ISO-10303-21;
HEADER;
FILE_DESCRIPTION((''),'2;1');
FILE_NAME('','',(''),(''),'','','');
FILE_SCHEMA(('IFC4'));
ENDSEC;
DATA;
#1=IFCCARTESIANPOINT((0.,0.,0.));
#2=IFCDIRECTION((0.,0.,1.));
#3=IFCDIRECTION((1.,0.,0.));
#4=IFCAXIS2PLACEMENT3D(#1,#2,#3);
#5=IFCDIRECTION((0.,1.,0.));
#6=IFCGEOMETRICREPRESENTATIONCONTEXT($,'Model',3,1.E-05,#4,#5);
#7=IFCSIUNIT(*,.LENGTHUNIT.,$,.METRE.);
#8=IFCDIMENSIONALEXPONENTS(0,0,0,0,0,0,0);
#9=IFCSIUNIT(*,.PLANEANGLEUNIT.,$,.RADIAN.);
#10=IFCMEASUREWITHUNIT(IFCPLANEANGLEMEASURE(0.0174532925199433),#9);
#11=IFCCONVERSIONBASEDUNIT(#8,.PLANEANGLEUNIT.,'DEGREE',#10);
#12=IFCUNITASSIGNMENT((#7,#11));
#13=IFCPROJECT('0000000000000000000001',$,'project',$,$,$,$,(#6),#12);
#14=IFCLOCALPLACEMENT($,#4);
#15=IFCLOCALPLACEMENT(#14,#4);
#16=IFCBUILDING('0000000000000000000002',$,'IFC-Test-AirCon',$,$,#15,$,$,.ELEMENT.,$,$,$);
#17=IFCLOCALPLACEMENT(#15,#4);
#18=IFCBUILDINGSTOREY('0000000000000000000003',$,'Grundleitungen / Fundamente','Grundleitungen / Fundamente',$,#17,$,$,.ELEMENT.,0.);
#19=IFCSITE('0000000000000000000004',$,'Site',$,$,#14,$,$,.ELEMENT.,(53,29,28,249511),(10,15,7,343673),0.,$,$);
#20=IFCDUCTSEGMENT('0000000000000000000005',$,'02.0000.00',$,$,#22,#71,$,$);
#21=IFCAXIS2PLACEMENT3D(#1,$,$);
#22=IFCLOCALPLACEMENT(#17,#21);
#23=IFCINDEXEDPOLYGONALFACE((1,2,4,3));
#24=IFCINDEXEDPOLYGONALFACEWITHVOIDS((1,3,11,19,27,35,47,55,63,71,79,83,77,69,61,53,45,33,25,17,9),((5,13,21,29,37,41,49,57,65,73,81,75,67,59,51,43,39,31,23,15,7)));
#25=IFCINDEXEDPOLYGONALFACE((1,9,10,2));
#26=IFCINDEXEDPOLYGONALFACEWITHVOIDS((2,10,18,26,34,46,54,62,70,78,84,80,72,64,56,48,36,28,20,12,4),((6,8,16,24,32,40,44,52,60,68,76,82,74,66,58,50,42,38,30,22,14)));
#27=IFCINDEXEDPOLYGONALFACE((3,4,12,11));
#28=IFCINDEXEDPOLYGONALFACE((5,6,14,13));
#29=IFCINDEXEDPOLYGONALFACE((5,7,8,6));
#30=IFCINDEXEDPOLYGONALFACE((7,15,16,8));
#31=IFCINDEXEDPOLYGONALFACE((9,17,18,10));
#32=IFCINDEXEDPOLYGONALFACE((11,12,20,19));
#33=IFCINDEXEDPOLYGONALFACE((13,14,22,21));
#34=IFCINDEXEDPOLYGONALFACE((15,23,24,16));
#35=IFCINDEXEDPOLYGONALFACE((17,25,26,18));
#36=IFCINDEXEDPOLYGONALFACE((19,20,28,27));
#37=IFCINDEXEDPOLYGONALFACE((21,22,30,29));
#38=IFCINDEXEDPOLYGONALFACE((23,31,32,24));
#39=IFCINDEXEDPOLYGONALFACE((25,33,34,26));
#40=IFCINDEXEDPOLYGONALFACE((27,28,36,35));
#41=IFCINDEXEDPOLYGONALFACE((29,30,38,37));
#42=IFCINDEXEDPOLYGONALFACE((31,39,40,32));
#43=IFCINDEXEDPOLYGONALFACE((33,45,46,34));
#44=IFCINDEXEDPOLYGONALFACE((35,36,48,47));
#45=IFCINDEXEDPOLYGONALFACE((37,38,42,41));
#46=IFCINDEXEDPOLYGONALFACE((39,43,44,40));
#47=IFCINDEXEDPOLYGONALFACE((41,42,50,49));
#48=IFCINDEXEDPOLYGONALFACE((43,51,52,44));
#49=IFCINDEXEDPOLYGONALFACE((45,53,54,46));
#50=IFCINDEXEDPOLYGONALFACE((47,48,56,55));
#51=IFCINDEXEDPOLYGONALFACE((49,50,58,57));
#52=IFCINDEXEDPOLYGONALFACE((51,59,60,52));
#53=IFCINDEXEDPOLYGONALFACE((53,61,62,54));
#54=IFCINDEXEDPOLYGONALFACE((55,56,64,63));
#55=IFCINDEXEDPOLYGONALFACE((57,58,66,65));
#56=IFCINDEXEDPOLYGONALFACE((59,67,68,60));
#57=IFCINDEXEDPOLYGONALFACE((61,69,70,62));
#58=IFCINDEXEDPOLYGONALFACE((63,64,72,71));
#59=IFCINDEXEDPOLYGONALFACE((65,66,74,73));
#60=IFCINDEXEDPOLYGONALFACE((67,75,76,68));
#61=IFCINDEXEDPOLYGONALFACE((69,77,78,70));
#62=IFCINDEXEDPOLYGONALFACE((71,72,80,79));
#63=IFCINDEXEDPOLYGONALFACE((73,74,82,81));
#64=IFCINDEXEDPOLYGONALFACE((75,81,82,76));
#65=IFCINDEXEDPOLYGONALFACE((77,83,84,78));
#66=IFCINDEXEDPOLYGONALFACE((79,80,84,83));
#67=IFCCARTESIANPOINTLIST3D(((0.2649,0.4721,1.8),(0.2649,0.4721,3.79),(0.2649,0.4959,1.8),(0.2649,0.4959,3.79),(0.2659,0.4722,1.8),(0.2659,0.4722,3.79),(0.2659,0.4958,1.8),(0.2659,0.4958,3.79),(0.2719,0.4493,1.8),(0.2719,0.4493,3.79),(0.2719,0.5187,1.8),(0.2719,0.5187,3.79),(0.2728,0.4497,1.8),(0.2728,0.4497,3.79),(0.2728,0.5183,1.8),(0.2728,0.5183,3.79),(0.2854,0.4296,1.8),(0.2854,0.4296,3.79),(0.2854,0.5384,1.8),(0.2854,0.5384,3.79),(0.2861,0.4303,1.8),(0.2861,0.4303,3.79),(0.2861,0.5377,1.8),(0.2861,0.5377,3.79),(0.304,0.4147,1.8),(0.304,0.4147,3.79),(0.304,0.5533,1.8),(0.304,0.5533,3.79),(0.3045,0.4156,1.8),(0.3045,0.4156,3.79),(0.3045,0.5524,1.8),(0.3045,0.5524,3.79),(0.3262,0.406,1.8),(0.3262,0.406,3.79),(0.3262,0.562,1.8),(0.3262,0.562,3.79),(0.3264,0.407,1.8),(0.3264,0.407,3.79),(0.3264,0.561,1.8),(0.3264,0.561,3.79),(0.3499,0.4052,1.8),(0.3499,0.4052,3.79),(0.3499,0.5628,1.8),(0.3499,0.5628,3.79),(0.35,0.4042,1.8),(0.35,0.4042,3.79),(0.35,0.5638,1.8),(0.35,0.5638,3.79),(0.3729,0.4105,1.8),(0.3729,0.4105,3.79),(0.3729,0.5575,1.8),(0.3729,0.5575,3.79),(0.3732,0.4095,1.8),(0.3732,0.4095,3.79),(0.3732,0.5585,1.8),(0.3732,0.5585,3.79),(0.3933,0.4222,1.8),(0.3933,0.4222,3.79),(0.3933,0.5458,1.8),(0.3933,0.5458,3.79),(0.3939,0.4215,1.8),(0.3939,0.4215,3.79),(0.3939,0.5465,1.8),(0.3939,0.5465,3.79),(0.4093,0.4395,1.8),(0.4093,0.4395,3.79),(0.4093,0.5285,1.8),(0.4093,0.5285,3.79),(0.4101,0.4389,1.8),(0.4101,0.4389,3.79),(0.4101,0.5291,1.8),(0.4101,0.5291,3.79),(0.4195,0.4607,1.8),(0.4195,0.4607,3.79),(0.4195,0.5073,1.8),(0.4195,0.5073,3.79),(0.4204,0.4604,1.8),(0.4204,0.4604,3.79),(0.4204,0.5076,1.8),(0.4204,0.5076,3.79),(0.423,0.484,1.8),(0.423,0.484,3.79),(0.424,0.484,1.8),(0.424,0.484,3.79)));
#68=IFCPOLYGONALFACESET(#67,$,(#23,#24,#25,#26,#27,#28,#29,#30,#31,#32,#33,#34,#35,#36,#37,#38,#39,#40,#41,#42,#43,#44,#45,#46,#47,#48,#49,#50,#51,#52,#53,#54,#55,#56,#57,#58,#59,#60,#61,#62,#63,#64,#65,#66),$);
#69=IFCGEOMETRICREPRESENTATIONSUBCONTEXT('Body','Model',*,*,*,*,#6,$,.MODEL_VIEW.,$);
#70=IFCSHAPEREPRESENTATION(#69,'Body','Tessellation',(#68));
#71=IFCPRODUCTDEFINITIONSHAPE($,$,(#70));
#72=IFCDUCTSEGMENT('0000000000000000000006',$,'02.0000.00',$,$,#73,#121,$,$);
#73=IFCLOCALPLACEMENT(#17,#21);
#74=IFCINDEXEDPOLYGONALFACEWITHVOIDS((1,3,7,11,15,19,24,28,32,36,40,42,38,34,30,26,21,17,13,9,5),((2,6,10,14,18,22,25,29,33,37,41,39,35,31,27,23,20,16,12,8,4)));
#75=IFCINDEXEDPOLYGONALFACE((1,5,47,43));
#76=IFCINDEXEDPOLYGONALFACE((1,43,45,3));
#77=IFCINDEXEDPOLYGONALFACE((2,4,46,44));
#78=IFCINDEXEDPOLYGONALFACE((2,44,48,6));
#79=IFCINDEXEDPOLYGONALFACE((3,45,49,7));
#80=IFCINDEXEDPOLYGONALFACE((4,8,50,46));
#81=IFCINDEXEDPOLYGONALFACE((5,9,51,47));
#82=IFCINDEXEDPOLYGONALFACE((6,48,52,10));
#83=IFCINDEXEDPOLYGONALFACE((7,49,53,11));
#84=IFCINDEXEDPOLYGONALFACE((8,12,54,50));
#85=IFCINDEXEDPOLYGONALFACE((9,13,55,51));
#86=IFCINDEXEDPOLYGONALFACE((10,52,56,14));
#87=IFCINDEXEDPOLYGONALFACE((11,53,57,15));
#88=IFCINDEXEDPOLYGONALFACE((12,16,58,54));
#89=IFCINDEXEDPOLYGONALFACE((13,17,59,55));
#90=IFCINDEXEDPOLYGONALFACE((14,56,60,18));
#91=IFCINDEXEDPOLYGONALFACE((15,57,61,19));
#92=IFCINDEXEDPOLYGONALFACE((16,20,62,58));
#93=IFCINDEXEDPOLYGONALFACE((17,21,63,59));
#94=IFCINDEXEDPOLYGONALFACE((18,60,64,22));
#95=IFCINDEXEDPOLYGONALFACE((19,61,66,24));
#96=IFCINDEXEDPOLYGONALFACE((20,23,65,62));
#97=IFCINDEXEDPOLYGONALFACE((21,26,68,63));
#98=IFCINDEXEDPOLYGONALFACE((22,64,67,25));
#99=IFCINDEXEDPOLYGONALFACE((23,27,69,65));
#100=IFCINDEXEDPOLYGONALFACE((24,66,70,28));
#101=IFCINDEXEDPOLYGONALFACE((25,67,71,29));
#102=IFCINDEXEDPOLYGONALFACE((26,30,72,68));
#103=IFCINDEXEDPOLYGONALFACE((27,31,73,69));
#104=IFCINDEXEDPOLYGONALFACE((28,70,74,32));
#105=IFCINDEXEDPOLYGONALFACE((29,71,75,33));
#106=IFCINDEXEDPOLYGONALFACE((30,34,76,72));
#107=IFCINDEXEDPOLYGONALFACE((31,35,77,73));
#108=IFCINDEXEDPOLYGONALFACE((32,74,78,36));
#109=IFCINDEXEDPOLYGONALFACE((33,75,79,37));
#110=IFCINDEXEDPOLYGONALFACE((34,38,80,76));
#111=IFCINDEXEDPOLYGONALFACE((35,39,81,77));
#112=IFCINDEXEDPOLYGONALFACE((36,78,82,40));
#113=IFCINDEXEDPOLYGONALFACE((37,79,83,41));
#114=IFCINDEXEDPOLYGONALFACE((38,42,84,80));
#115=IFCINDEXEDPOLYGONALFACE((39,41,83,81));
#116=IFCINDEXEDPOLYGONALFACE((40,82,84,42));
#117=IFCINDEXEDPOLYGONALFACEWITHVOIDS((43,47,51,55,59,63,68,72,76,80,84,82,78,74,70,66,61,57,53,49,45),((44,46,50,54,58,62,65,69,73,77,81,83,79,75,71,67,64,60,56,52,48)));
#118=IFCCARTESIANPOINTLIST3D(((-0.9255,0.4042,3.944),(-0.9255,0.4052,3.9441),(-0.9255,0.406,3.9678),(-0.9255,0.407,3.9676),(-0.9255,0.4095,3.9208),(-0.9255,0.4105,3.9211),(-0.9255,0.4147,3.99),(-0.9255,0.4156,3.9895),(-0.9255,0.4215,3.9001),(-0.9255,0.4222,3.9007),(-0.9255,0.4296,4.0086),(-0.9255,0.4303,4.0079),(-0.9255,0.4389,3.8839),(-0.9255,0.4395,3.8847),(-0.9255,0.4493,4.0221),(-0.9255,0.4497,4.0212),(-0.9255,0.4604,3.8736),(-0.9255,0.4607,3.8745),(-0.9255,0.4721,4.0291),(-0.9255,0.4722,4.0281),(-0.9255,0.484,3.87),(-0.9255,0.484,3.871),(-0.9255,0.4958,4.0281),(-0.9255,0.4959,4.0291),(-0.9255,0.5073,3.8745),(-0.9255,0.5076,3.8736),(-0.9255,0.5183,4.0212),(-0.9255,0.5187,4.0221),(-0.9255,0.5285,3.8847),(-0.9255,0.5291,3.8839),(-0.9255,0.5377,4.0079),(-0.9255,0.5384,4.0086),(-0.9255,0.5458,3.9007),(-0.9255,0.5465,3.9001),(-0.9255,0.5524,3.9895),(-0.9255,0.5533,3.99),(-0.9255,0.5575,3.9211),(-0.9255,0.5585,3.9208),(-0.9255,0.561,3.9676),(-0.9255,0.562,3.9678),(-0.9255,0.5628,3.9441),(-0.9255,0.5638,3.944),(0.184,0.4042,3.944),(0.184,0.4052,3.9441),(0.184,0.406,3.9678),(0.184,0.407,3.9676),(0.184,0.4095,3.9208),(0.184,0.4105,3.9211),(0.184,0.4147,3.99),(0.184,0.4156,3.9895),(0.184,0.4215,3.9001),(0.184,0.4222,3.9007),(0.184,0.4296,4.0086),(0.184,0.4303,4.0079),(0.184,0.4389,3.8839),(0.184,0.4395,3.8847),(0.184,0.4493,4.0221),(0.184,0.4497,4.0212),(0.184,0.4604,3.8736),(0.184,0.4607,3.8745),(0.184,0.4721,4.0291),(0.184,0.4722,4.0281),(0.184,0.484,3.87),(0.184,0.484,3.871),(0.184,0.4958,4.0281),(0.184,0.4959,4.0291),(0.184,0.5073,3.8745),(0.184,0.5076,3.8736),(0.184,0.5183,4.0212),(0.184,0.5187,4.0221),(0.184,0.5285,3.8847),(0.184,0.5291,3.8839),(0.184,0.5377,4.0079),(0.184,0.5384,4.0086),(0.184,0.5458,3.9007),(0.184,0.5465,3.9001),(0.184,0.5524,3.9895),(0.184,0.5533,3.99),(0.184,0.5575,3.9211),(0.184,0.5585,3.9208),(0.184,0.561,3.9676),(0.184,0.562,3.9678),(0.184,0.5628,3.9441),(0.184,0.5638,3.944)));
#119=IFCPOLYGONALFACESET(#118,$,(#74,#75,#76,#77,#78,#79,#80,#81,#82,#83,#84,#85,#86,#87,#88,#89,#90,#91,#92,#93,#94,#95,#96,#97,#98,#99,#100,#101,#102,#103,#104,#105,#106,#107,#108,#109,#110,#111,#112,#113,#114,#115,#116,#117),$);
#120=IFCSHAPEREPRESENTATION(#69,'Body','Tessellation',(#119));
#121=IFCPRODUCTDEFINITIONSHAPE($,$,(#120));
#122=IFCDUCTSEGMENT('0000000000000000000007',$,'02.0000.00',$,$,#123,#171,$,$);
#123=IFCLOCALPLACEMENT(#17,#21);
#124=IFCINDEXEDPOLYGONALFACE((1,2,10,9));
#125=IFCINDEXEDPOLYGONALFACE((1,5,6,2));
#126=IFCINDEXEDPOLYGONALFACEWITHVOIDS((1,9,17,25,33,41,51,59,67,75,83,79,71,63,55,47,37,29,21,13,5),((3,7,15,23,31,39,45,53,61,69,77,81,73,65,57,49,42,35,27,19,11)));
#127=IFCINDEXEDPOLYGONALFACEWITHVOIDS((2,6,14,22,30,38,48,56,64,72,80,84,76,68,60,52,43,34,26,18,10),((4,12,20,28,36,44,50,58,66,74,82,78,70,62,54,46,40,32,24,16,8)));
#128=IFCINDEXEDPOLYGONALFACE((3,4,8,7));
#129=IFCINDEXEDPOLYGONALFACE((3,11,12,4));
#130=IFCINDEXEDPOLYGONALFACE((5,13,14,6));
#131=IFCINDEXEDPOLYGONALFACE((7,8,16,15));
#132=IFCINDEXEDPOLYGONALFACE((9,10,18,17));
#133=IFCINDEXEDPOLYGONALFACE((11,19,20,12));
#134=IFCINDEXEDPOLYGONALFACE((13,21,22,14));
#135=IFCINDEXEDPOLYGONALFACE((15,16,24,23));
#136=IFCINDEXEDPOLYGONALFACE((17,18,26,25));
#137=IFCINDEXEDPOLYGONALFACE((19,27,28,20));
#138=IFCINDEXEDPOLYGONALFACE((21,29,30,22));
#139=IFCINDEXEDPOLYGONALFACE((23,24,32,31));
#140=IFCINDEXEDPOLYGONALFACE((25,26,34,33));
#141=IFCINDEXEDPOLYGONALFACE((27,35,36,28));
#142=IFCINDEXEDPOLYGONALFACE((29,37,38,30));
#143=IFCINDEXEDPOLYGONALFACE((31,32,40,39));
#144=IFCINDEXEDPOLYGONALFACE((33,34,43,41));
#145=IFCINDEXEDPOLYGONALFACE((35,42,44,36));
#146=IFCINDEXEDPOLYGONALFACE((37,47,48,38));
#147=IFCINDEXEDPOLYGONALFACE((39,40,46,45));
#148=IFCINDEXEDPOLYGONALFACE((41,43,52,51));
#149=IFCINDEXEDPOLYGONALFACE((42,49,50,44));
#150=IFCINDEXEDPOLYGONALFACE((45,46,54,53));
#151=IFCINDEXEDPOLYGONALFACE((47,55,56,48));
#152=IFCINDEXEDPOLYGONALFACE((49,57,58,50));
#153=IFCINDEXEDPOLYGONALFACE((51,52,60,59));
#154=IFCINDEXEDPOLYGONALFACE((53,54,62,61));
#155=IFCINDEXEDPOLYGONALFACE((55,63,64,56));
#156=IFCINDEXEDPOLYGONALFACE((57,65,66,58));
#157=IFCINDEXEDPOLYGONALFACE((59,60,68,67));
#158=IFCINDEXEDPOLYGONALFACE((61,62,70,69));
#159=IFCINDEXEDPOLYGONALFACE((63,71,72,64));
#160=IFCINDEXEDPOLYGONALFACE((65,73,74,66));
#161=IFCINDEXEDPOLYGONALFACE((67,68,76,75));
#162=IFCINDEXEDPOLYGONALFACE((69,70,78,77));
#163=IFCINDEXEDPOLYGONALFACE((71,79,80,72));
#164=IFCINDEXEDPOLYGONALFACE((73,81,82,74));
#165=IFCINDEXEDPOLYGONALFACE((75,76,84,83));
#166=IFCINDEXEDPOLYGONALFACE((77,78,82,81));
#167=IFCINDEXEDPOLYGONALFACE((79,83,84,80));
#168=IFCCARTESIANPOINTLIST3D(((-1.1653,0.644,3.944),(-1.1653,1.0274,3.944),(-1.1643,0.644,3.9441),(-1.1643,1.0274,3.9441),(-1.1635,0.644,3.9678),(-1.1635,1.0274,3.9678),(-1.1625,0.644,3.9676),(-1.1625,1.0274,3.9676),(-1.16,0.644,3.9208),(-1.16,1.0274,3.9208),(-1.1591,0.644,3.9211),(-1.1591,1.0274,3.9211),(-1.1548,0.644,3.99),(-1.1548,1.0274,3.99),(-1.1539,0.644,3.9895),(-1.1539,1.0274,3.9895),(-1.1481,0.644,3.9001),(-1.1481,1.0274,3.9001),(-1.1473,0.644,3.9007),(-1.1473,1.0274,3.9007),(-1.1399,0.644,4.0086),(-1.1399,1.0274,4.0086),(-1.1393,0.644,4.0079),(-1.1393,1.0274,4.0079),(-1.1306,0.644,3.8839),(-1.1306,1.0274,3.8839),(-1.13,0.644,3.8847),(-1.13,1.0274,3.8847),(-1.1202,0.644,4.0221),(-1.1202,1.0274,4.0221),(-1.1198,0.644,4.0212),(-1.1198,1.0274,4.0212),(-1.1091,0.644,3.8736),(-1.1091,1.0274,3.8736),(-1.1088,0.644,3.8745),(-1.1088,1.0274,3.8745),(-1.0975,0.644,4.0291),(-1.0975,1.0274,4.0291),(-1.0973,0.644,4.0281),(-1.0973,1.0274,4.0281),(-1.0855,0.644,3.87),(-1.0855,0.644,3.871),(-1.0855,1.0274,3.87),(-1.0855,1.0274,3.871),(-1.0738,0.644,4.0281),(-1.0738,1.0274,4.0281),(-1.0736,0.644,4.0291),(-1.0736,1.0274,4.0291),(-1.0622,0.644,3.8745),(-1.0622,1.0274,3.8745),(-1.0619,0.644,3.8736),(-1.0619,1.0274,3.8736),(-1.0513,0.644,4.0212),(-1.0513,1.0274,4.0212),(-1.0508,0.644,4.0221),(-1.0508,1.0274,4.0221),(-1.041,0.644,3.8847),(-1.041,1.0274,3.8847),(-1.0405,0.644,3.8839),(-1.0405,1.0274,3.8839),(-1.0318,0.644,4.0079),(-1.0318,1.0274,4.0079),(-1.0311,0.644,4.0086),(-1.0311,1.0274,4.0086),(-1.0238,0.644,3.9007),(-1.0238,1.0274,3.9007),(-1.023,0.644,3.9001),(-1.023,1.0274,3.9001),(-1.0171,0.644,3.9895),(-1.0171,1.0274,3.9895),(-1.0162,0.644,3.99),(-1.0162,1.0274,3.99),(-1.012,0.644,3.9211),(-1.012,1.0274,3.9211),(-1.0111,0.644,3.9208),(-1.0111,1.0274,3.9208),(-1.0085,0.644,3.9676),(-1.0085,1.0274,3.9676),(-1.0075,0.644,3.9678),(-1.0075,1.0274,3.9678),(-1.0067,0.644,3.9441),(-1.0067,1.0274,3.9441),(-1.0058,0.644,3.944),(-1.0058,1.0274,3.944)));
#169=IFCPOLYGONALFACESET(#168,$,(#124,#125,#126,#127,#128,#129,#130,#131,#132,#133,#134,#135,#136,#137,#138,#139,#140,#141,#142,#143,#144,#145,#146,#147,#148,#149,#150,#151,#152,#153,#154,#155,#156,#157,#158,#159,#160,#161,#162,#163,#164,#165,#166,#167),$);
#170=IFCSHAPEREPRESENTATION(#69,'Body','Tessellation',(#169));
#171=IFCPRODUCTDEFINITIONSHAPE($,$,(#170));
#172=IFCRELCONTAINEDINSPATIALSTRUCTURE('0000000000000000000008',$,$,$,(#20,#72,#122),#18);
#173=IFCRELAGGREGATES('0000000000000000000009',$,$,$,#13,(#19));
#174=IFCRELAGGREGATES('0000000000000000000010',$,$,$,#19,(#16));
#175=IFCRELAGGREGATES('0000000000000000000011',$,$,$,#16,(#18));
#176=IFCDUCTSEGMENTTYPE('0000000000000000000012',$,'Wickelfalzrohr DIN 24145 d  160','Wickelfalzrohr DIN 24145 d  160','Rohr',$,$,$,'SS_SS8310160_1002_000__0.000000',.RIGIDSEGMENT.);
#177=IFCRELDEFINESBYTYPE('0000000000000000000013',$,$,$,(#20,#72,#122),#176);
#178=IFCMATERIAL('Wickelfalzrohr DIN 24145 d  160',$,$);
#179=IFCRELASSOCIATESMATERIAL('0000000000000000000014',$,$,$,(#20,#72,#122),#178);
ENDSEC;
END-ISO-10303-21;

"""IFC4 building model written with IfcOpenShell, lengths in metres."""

from ifc_helpers import new_model, entity, si_unit, converted_unit, direction, frame, origin_with_axes, origin_2d_with_axis, place, context, subcontext, project, spatial, hollow_circle, extrude, material, type_object, element, save


model = new_model("IFC4")

# Units and contexts
model_context = context("Model", 3, precision=1e-05, world=origin_with_axes(), true_north=direction((0.0, 1.0, 0.0)))
body_context = subcontext(model_context, "Body", "Model", "MODEL_VIEW")
ifc_project = project(units=[si_unit("LENGTHUNIT", "METRE"), converted_unit("PLANEANGLEUNIT", "DEGREE", entity("IfcPlaneAngleMeasure", 0.0174532925199433), si_unit("PLANEANGLEUNIT", "RADIAN"), dimensions=[0, 0, 0, 0, 0, 0, 0])], contexts=[model_context])

# Site, building, storey
site_placement = place(None, origin_with_axes())
site = spatial("IfcSite", under=ifc_project, at=site_placement, Name="Site", CompositionType="ELEMENT", RefLatitude=(53, 29, 28, 249511), RefLongitude=(10, 15, 7, 343673), RefElevation=0.0)
building_placement = place(site_placement, origin_with_axes())
building = spatial("IfcBuilding", under=site, at=building_placement, Name="IFC-Test-AirCon", CompositionType="ELEMENT")
storey_placement = place(building_placement, origin_with_axes())
storey = spatial("IfcBuildingStorey", under=building, at=storey_placement, Name="Grundleitungen / Fundamente", Description="Grundleitungen / Fundamente", CompositionType="ELEMENT", Elevation=0.0)

# Duct segments
ifc_material_1 = material(Name="Wickelfalzrohr DIN 24145 d  160")
duct_segment_type_1 = type_object("IfcDuctSegmentType", Name="Wickelfalzrohr DIN 24145 d  160", Description="Wickelfalzrohr DIN 24145 d  160", ApplicableOccurrence="Rohr", ElementType="SS_SS8310160_1002_000__0.000000", PredefinedType="RIGIDSEGMENT")
duct_segment_1_placement = place(storey_placement, frame((0.344, 0.484, 1.8), z_axis=(-1.0, 0.0, 0.0), x_axis=(0.0, 0.0, 1.0)))
element("IfcDuctSegment", 1, at=duct_segment_1_placement, inside=storey, type_object=duct_segment_type_1, material=ifc_material_1, Name="02.0000.00", context=body_context, shape_type="SweptSolid", body=[
    extrude(hollow_circle(Radius=0.08, WallThickness=0.001, at=origin_2d_with_axis()), frame((0.0, 0.0, 0.0), z_axis=(1.0, 0.0, 0.0), x_axis=(0.0, 0.0, -1.0)), (0.0, 0.0, 1.0), 1.99),
])
duct_segment_2_placement = place(storey_placement, frame((0.184, 0.484, 3.95), z_axis=(0.0, 0.0, 1.0), x_axis=(-1.0, 0.0, 0.0)))
element("IfcDuctSegment", 2, at=duct_segment_2_placement, inside=storey, type_object=duct_segment_type_1, material=ifc_material_1, Name="02.0000.00", context=body_context, shape_type="SweptSolid", body=[
    extrude(hollow_circle(Radius=0.08, WallThickness=0.001, at=origin_2d_with_axis()), frame((0.0, 0.0, 0.0), z_axis=(1.0, 0.0, 0.0), x_axis=(0.0, 0.0, -1.0)), (0.0, 0.0, 1.0), 1.1095),
])
duct_segment_3_placement = place(storey_placement, frame((-1.0855, 0.644, 3.95), z_axis=(0.0, 0.0, 1.0), x_axis=(0.0, 1.0, 0.0)))
element("IfcDuctSegment", 3, at=duct_segment_3_placement, inside=storey, type_object=duct_segment_type_1, material=ifc_material_1, Name="02.0000.00", context=body_context, shape_type="SweptSolid", body=[
    extrude(hollow_circle(Radius=0.08, WallThickness=0.001, at=origin_2d_with_axis()), frame((0.0, 0.0, 0.0), z_axis=(1.0, 0.0, 0.0), x_axis=(0.0, 0.0, -1.0)), (0.0, 0.0, 1.0), 0.3834),
])

save(model, "model.ifc")
